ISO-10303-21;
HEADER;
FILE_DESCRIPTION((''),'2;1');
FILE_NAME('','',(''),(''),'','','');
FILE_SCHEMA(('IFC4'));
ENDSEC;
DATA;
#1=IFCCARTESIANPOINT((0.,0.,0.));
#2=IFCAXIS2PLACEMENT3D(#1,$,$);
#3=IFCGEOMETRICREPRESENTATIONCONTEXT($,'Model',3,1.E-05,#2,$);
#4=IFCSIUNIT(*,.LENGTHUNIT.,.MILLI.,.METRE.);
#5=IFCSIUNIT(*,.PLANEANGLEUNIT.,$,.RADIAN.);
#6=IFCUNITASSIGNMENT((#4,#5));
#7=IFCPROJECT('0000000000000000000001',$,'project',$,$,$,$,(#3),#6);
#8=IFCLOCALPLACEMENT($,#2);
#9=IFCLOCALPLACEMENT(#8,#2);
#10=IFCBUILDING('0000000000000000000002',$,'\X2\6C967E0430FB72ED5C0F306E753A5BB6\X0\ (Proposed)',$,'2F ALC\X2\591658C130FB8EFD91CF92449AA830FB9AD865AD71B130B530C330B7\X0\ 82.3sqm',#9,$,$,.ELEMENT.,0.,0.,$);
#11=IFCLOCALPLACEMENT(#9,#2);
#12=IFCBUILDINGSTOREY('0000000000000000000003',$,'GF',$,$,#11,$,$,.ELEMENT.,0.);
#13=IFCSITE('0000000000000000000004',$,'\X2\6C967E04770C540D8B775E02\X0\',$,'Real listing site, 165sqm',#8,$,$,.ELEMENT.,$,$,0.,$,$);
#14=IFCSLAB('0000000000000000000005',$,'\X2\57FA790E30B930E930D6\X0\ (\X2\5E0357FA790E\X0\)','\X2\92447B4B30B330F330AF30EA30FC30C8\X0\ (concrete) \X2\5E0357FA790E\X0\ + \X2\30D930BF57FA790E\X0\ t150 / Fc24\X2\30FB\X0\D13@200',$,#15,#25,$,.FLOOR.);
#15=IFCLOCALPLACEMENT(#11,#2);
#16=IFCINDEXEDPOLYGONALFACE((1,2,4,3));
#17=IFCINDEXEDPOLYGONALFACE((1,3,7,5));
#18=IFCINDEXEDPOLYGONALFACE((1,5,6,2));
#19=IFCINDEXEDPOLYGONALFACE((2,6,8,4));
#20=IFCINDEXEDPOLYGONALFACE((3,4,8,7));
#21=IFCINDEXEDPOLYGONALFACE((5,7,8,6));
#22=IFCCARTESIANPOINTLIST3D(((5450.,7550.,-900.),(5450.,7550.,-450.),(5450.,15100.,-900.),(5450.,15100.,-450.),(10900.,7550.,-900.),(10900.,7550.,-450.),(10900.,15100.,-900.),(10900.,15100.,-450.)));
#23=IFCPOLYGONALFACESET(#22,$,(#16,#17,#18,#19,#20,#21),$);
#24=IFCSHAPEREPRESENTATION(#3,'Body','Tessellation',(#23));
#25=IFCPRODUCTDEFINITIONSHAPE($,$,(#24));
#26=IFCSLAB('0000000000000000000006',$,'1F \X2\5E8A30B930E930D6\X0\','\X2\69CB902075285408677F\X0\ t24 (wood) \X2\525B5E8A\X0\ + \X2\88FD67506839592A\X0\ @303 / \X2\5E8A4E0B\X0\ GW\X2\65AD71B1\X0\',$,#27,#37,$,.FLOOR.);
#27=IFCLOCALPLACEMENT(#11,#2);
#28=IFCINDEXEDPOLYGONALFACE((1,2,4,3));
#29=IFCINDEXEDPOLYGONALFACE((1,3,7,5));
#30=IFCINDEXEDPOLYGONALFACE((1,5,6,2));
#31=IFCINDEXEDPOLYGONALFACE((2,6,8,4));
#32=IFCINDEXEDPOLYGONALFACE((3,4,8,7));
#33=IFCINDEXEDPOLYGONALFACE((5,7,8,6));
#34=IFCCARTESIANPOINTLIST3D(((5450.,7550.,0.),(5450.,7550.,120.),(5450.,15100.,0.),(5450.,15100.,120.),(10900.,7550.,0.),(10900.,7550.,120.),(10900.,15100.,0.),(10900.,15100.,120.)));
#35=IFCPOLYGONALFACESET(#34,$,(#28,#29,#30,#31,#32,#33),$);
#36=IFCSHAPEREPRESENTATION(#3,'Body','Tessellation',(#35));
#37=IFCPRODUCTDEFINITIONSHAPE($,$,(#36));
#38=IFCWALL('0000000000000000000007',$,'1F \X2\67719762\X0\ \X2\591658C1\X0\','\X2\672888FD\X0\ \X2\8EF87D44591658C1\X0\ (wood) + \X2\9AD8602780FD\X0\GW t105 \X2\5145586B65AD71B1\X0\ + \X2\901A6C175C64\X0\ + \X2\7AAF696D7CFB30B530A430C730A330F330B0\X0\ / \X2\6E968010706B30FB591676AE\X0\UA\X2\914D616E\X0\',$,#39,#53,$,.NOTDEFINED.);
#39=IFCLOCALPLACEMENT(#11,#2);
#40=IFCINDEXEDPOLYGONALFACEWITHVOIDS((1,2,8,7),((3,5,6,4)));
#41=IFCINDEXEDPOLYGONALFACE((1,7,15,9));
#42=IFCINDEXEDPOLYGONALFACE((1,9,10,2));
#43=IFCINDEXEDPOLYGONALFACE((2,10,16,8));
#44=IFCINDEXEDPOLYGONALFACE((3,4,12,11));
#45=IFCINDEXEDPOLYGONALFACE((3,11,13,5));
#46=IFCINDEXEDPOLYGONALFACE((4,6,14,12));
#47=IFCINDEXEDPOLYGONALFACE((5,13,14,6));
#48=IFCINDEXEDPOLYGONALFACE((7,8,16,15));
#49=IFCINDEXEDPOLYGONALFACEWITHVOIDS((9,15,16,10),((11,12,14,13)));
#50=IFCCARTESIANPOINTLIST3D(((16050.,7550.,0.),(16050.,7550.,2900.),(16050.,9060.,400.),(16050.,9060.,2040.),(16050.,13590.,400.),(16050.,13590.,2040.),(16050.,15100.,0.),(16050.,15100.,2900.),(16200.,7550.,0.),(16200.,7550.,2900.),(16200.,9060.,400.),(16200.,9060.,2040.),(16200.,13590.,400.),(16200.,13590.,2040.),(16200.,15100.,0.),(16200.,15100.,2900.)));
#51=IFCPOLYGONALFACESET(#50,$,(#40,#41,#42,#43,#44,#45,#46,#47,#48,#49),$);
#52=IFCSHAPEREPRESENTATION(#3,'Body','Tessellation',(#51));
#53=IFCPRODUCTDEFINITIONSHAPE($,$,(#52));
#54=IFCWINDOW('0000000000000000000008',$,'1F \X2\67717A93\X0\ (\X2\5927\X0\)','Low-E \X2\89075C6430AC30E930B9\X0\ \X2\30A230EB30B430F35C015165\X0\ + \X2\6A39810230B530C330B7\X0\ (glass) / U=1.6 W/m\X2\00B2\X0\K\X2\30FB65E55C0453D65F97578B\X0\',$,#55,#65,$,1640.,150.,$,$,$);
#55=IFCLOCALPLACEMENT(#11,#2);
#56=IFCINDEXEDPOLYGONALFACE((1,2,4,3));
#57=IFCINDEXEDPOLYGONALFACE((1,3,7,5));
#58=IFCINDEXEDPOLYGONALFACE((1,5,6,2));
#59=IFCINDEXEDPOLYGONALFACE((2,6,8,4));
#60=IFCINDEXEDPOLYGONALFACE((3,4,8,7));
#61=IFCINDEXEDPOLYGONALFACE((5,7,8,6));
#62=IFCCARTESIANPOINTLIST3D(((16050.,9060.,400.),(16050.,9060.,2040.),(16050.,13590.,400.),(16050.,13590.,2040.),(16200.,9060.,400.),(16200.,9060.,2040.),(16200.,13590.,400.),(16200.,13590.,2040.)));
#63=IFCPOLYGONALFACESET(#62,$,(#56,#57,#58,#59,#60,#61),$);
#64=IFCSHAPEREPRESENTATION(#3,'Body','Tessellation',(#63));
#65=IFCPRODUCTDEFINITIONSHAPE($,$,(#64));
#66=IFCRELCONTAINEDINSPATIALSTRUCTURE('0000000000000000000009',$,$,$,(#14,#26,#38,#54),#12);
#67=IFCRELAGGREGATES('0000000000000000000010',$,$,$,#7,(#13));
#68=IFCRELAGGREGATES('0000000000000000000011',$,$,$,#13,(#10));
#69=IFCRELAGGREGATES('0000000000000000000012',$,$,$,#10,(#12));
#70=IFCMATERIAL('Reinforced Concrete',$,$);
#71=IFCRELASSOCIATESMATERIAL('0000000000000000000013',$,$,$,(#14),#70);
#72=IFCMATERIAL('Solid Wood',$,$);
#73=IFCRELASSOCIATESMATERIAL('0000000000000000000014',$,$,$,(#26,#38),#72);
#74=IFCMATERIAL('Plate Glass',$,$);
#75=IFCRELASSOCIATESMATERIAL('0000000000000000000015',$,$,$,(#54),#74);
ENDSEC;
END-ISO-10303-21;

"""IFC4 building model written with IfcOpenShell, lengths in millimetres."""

from ifc_helpers import new_model, si_unit, frame, frame_2d, origin, place, context, project, spatial, rectangle, extrude, material, element, fill, save


model = new_model("IFC4")

# Units and contexts
model_context = context("Model", 3, precision=1e-05, world=origin())
ifc_project = project(units=[si_unit("LENGTHUNIT", "METRE", prefix="MILLI"), si_unit("PLANEANGLEUNIT", "RADIAN")], contexts=[model_context])

# Site, building, storey
site_placement = place(None, origin())
site = spatial("IfcSite", under=ifc_project, at=site_placement, Name="沖縄県名護市", ObjectType="Real listing site, 165sqm", CompositionType="ELEMENT", RefElevation=0.0)
building_placement = place(site_placement, origin())
building = spatial("IfcBuilding", under=site, at=building_placement, Name="沖縄・狭小の町家 (Proposed)", ObjectType="2F ALC外壁・軽量鉄骨・高断熱サッシ 82.3sqm", CompositionType="ELEMENT", ElevationOfRefHeight=0.0, ElevationOfTerrain=0.0)
storey_placement = place(building_placement, origin())
storey = spatial("IfcBuildingStorey", under=building, at=storey_placement, Name="GF", CompositionType="ELEMENT", Elevation=0.0)

# Shared definitions
ifc_material_1 = material(Name="Solid Wood")

# Slabs
ifc_material_2 = material(Name="Reinforced Concrete")
slab_1_placement = place(storey_placement, frame((2725.0, 3775.0, -450.0)))
element("IfcSlab", 1, at=slab_1_placement, inside=storey, material=ifc_material_2, Name="基礎スラブ (布基礎)", Description="鉄筋コンクリート (concrete) 布基礎 + ベタ基礎 t150 / Fc24・D13@200", PredefinedType="FLOOR", context=model_context, shape_type="SweptSolid", body=[
    extrude(rectangle(XDim=5450.0, YDim=7550.0, at=frame_2d((2725.0, 3775.0))), frame((2725.0, 3775.0, -450.0)), (0.0, 0.0, 1.0), 450.0),
])
slab_2_placement = place(storey_placement, frame((2725.0, 3775.0, 0.0)))
element("IfcSlab", 2, at=slab_2_placement, inside=storey, material=ifc_material_1, Name="1F 床スラブ", Description="構造用合板 t24 (wood) 剛床 + 製材根太 @303 / 床下 GW断熱", PredefinedType="FLOOR", context=model_context, shape_type="SweptSolid", body=[
    extrude(rectangle(XDim=5450.0, YDim=7550.0, at=frame_2d((2725.0, 3775.0))), frame((2725.0, 3775.0, 0.0)), (0.0, 0.0, 1.0), 120.0),
])

# Shared definitions
ifc_material_3 = material(Name="Plate Glass")

# Wall, opening, window
wall_1_placement = place(storey_placement, frame((8025.0, 3775.0, 0.0)))
wall_1 = element("IfcWall", 3, at=wall_1_placement, inside=storey, material=ifc_material_1, Name="1F 東面 外壁", Description="木製 軸組外壁 (wood) + 高性能GW t105 充填断熱 + 通気層 + 窯業系サイディング / 準耐火・外皮UA配慮", PredefinedType="NOTDEFINED", context=model_context, shape_type="SweptSolid", body=[
    extrude(rectangle(XDim=150.0, YDim=7550.0, at=frame_2d((75.0, 3775.0))), frame((8025.0, 3775.0, 0.0)), (0.0, 0.0, 1.0), 2900.0),
])
opening_1_placement = place(storey_placement, frame((8025.0, 4530.0, 200.0)))
opening_1 = element("IfcOpeningElement", 4, at=opening_1_placement, cuts=wall_1, PredefinedType="NOTDEFINED", context=model_context, shape_type="SweptSolid", body=[
    extrude(rectangle(XDim=150.0, YDim=4530.0, at=frame_2d((75.0, 2265.0))), frame((8025.0, 4530.0, 200.0)), (0.0, 0.0, 1.0), 1640.0),
])
window_1_placement = place(storey_placement, frame((8025.0, 4530.0, 200.0)))
window_1 = element("IfcWindow", 5, at=window_1_placement, inside=storey, material=ifc_material_3, Name="1F 東窓 (大)", Description="Low-E 複層ガラス アルゴン封入 + 樹脂サッシ (glass) / U=1.6 W/m²K・日射取得型", OverallHeight=1640.0, OverallWidth=150.0, context=model_context, shape_type="SweptSolid", body=[
    extrude(rectangle(XDim=150.0, YDim=4530.0, at=frame_2d((75.0, 2265.0))), frame((8025.0, 4530.0, 200.0)), (0.0, 0.0, 1.0), 1640.0),
])
fill(opening_1, window_1)

save(model, "model.ifc")
